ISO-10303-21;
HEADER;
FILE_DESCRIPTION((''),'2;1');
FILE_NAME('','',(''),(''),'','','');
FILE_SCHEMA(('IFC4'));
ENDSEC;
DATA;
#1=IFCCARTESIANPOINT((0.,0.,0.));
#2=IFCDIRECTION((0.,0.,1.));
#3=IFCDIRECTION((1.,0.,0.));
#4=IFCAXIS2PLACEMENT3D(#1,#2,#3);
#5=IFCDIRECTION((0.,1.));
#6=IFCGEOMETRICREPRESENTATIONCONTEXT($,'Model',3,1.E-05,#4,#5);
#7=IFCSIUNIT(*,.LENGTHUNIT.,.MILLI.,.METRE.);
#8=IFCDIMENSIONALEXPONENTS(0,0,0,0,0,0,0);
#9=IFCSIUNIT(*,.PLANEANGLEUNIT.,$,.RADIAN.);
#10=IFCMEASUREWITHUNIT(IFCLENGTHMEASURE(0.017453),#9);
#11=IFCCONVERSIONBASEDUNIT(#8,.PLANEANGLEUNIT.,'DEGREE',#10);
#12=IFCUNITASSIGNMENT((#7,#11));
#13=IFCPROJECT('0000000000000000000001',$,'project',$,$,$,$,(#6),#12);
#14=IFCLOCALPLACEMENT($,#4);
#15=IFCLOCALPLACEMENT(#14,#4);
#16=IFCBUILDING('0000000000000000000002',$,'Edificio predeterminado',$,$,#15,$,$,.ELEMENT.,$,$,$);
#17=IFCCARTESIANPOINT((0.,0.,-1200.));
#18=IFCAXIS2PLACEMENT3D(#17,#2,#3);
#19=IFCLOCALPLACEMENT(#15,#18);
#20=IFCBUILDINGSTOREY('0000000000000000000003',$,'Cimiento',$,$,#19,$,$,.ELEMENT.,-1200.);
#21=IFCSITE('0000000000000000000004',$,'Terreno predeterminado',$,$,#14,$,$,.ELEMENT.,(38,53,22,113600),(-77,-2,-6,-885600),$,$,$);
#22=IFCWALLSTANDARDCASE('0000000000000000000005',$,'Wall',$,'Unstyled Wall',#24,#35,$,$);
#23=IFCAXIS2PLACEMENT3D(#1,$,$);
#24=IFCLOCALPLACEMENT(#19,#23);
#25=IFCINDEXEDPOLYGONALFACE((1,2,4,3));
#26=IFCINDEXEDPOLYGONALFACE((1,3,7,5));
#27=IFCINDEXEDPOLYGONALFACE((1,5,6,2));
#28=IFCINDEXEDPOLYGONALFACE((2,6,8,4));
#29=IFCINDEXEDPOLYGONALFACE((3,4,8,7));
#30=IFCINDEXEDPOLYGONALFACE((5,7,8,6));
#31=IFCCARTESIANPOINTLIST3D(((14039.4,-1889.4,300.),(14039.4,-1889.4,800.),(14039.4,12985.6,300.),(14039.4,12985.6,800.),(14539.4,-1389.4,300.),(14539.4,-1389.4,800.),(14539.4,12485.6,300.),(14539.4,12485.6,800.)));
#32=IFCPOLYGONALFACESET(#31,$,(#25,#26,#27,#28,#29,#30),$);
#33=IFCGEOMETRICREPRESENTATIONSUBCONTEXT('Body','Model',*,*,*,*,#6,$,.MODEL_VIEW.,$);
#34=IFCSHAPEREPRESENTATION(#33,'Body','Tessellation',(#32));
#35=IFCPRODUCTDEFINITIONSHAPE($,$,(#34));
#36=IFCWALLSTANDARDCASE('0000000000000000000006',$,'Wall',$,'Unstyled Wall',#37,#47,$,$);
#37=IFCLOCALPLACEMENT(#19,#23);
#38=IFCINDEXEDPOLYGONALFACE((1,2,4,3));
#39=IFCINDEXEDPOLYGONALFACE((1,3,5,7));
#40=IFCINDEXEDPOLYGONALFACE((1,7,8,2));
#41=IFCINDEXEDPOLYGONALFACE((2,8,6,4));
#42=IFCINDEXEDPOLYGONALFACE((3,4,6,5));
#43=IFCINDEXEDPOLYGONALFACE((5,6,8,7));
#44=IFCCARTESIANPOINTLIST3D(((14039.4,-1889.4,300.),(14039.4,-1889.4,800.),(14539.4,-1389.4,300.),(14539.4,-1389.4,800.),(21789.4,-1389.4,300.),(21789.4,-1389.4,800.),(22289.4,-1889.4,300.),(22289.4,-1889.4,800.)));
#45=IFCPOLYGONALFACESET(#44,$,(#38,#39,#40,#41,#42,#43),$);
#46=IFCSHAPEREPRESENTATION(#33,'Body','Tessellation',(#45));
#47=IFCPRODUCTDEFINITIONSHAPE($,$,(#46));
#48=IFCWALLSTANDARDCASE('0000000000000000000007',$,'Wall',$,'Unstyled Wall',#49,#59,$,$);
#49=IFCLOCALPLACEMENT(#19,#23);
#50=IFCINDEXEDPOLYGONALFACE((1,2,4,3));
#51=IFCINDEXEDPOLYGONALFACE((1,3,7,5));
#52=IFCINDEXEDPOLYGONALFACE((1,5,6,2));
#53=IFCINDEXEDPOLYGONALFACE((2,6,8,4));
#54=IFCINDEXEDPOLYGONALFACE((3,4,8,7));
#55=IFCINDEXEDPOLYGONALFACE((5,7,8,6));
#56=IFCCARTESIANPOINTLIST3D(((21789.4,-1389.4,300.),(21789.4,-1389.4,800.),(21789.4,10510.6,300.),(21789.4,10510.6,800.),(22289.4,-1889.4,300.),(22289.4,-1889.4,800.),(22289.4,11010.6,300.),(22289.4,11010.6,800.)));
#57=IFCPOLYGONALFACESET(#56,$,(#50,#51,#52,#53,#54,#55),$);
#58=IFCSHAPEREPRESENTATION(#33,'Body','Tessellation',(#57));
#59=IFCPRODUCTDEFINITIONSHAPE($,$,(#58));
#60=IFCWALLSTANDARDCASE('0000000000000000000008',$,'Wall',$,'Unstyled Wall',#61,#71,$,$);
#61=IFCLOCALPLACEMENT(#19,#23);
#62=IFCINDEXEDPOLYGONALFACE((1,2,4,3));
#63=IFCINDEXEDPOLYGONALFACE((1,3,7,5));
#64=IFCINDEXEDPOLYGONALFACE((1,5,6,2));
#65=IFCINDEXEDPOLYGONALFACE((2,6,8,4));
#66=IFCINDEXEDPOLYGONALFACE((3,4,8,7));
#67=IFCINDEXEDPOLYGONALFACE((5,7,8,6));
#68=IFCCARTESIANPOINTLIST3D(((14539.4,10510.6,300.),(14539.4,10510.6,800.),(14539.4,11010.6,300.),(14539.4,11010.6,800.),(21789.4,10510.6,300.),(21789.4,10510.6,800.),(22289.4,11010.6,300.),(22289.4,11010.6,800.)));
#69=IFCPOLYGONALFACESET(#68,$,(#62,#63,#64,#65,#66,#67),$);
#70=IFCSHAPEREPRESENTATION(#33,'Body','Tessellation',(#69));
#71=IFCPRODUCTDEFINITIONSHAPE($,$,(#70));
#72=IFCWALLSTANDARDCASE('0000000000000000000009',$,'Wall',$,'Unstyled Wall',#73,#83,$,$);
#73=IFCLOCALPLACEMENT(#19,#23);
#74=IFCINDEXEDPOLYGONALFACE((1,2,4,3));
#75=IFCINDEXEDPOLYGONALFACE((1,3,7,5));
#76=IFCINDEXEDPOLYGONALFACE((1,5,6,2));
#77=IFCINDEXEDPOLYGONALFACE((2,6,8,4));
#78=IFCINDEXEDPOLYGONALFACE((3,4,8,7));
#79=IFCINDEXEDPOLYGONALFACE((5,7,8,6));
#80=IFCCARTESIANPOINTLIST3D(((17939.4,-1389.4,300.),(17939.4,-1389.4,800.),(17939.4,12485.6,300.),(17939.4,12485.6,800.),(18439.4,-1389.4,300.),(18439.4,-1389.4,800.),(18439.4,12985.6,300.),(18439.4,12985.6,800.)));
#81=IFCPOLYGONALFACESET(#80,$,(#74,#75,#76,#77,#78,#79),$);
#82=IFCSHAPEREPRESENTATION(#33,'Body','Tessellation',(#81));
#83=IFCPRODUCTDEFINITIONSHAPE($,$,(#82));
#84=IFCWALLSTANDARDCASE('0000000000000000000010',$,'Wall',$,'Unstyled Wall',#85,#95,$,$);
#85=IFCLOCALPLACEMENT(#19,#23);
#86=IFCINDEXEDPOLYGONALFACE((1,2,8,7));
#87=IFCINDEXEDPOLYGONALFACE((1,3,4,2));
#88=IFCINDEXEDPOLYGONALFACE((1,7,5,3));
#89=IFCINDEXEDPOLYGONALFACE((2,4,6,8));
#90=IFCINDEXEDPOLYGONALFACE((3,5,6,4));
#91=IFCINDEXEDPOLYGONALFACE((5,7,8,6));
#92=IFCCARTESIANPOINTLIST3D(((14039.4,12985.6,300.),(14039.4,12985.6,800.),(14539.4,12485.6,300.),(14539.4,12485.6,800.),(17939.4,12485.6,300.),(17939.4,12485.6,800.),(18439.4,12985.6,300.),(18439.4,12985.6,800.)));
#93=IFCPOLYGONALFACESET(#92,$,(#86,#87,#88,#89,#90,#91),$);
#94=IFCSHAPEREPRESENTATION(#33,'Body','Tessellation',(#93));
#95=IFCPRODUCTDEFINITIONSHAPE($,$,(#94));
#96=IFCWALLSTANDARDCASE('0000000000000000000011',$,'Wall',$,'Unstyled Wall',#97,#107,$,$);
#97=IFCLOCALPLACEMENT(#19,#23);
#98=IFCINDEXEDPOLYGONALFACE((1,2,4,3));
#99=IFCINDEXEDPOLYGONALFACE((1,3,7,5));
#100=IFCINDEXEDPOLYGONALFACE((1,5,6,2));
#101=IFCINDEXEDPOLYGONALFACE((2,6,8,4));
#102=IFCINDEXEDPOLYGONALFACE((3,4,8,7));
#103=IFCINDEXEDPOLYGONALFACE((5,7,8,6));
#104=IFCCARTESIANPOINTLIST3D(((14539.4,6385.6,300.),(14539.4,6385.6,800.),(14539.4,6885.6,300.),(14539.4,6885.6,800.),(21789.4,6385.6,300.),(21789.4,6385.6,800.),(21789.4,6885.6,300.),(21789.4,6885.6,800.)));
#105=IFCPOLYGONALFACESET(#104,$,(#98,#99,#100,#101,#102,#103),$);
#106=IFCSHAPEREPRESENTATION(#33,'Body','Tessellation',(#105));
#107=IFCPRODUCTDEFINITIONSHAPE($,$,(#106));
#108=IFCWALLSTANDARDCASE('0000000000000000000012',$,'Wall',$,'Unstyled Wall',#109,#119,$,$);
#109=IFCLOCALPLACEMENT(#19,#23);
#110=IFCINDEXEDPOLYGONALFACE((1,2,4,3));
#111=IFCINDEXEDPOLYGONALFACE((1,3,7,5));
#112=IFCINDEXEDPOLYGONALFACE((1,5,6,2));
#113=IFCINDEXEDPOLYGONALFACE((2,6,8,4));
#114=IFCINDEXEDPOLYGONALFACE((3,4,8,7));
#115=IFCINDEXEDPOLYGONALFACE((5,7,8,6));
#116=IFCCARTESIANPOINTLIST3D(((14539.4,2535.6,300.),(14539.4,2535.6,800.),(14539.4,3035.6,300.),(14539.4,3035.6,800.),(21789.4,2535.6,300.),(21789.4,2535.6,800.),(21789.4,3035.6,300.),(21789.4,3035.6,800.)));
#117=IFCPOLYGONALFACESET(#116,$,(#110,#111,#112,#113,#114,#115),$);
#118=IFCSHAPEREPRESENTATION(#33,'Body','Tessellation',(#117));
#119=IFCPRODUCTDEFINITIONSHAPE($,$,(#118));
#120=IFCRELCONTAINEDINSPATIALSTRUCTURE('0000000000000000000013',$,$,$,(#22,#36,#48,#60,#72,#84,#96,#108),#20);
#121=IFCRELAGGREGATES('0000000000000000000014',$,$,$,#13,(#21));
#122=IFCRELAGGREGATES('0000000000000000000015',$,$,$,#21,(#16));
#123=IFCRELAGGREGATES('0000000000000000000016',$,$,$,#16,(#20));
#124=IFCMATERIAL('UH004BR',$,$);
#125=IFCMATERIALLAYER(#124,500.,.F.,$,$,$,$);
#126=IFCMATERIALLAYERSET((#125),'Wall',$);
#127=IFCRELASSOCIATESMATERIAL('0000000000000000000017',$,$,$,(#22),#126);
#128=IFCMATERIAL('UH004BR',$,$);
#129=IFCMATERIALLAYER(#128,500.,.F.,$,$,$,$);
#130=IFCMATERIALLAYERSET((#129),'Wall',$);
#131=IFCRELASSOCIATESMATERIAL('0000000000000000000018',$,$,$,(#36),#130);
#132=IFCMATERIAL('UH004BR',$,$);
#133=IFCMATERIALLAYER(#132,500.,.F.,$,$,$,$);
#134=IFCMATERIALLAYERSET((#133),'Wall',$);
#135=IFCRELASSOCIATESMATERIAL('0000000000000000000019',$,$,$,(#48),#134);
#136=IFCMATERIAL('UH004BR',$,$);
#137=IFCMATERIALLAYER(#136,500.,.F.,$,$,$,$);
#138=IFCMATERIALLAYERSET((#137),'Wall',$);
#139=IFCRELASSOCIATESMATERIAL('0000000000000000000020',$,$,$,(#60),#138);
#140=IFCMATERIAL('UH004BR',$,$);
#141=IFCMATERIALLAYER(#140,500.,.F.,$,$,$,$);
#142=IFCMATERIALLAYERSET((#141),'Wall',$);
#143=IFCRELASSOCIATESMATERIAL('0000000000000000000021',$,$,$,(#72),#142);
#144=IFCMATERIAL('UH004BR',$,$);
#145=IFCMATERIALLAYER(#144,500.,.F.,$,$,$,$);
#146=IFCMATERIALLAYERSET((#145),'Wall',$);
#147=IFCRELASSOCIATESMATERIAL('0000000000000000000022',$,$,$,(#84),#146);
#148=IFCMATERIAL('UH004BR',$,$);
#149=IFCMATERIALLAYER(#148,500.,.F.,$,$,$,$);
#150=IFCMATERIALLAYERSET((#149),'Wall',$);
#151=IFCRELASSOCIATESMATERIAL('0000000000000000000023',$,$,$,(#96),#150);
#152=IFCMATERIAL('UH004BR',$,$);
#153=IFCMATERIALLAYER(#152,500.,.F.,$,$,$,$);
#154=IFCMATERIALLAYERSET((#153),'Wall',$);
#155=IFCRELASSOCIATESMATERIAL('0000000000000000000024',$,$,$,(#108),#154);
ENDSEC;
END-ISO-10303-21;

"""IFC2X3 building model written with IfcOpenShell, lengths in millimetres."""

from ifc_helpers import new_model, entity, si_unit, converted_unit, direction, frame, origin_with_axes, place, context, subcontext, project, spatial, polyline, outline, extrude, material, layer, layer_set, layer_usage, element, save


model = new_model("IFC2X3")

# Units and contexts
model_context = context("Model", 3, precision=1e-05, world=origin_with_axes(), true_north=direction((0.0, 1.0)))
body_context = subcontext(model_context, "Body", "Model", "MODEL_VIEW")
ifc_project = project(units=[si_unit("LENGTHUNIT", "METRE", prefix="MILLI"), converted_unit("PLANEANGLEUNIT", "DEGREE", entity("IfcLengthMeasure", 0.017453), si_unit("PLANEANGLEUNIT", "RADIAN"), dimensions=[0, 0, 0, 0, 0, 0, 0])], contexts=[model_context])

# Site, building, storey
site_placement = place(None, origin_with_axes())
site = spatial("IfcSite", under=ifc_project, at=site_placement, Name="Terreno predeterminado", CompositionType="ELEMENT", RefLatitude=(38, 53, 22, 113600), RefLongitude=(-77, -2, -6, -885600))
building_placement = place(site_placement, origin_with_axes())
building = spatial("IfcBuilding", under=site, at=building_placement, Name="Edificio predeterminado", CompositionType="ELEMENT")
storey_placement = place(building_placement, frame((0.0, 0.0, -1200.0), z_axis=(0.0, 0.0, 1.0), x_axis=(1.0, 0.0, 0.0)))
storey = spatial("IfcBuildingStorey", under=building, at=storey_placement, Name="Cimiento", CompositionType="ELEMENT", Elevation=-1200.0)

# Walls
ifc_material_1 = material(Name="UH004BR")
ifc_layer_1 = layer(ifc_material_1, 500.0, ventilated=False)
ifc_layer_set_1 = layer_set([ifc_layer_1], Name="Wall")
ifc_layer_usage_1 = layer_usage(ifc_layer_set_1, "AXIS2", "POSITIVE", -250.0)
wall_1_placement = place(storey_placement, frame((14289.4, 12735.6, 300.0), z_axis=(0.0, 0.0, 1.0), x_axis=(0.0, -1.0, 0.0)))
element("IfcWallStandardCase", 1, at=wall_1_placement, inside=storey, material=ifc_layer_usage_1, Name="Wall", ObjectType="Unstyled Wall", context=body_context, shape_type="SweptSolid", body=[
    extrude(outline(polyline([(250.0, 250.0), (-250.0, -250.0), (14625.0, -250.0), (14125.0, 250.0), (250.0, 250.0)])), origin_with_axes(), (0.0, 0.0, 1.0), 500.0),
])
ifc_material_2 = material(Name="UH004BR")
ifc_layer_2 = layer(ifc_material_2, 500.0, ventilated=False)
ifc_layer_set_2 = layer_set([ifc_layer_2], Name="Wall")
ifc_layer_usage_2 = layer_usage(ifc_layer_set_2, "AXIS2", "POSITIVE", -250.0)
wall_2_placement = place(storey_placement, frame((14289.4, -1639.4, 300.0), z_axis=(0.0, 0.0, 1.0), x_axis=(1.0, 0.0, 0.0)))
element("IfcWallStandardCase", 2, at=wall_2_placement, inside=storey, material=ifc_layer_usage_2, Name="Wall", ObjectType="Unstyled Wall", context=body_context, shape_type="SweptSolid", body=[
    extrude(outline(polyline([(-250.0, -250.0), (250.0, 250.0), (7500.0, 250.0), (8000.0, -250.0), (-250.0, -250.0)])), origin_with_axes(), (0.0, 0.0, 1.0), 500.0),
])
ifc_material_3 = material(Name="UH004BR")
ifc_layer_3 = layer(ifc_material_3, 500.0, ventilated=False)
ifc_layer_set_3 = layer_set([ifc_layer_3], Name="Wall")
ifc_layer_usage_3 = layer_usage(ifc_layer_set_3, "AXIS2", "POSITIVE", -250.0)
wall_3_placement = place(storey_placement, frame((22039.4, -1639.4, 300.0), z_axis=(0.0, 0.0, 1.0), x_axis=(0.0, 1.0, 0.0)))
element("IfcWallStandardCase", 3, at=wall_3_placement, inside=storey, material=ifc_layer_usage_3, Name="Wall", ObjectType="Unstyled Wall", context=body_context, shape_type="SweptSolid", body=[
    extrude(outline(polyline([(-250.0, -250.0), (250.0, 250.0), (12150.0, 250.0), (12650.0, -250.0), (-250.0, -250.0)])), origin_with_axes(), (0.0, 0.0, 1.0), 500.0),
])
ifc_material_4 = material(Name="UH004BR")
ifc_layer_4 = layer(ifc_material_4, 500.0, ventilated=False)
ifc_layer_set_4 = layer_set([ifc_layer_4], Name="Wall")
ifc_layer_usage_4 = layer_usage(ifc_layer_set_4, "AXIS2", "POSITIVE", -250.0)
wall_4_placement = place(storey_placement, frame((22039.4, 10760.6, 300.0), z_axis=(0.0, 0.0, 1.0), x_axis=(-1.0, 0.0, 0.0)))
element("IfcWallStandardCase", 4, at=wall_4_placement, inside=storey, material=ifc_layer_usage_4, Name="Wall", ObjectType="Unstyled Wall", context=body_context, shape_type="SweptSolid", body=[
    extrude(outline(polyline([(-250.0, -250.0), (250.0, 250.0), (7500.0, 250.0), (7500.0, -250.0), (-250.0, -250.0)])), origin_with_axes(), (0.0, 0.0, 1.0), 500.0),
])
ifc_material_5 = material(Name="UH004BR")
ifc_layer_5 = layer(ifc_material_5, 500.0, ventilated=False)
ifc_layer_set_5 = layer_set([ifc_layer_5], Name="Wall")
ifc_layer_usage_5 = layer_usage(ifc_layer_set_5, "AXIS2", "POSITIVE", -250.0)
wall_5_placement = place(storey_placement, frame((18189.4, -1639.4, 300.0), z_axis=(0.0, 0.0, 1.0), x_axis=(0.0, 1.0, 0.0)))
element("IfcWallStandardCase", 5, at=wall_5_placement, inside=storey, material=ifc_layer_usage_5, Name="Wall", ObjectType="Unstyled Wall", context=body_context, shape_type="SweptSolid", body=[
    extrude(outline(polyline([(250.0, 250.0), (250.0, -250.0), (14625.0, -250.0), (14125.0, 250.0), (250.0, 250.0)])), origin_with_axes(), (0.0, 0.0, 1.0), 500.0),
])
ifc_material_6 = material(Name="UH004BR")
ifc_layer_6 = layer(ifc_material_6, 500.0, ventilated=False)
ifc_layer_set_6 = layer_set([ifc_layer_6], Name="Wall")
ifc_layer_usage_6 = layer_usage(ifc_layer_set_6, "AXIS2", "POSITIVE", -250.0)
wall_6_placement = place(storey_placement, frame((18189.4, 12735.6, 300.0), z_axis=(0.0, 0.0, 1.0), x_axis=(-1.0, 0.0, 0.0)))
element("IfcWallStandardCase", 6, at=wall_6_placement, inside=storey, material=ifc_layer_usage_6, Name="Wall", ObjectType="Unstyled Wall", context=body_context, shape_type="SweptSolid", body=[
    extrude(outline(polyline([(-250.0, -250.0), (250.0, 250.0), (3650.0, 250.0), (4150.0, -250.0), (-250.0, -250.0)])), origin_with_axes(), (0.0, 0.0, 1.0), 500.0),
])
ifc_material_7 = material(Name="UH004BR")
ifc_layer_7 = layer(ifc_material_7, 500.0, ventilated=False)
ifc_layer_set_7 = layer_set([ifc_layer_7], Name="Wall")
ifc_layer_usage_7 = layer_usage(ifc_layer_set_7, "AXIS2", "POSITIVE", -250.0)
wall_7_placement = place(storey_placement, frame((14289.4, 6635.6, 300.0), z_axis=(0.0, 0.0, 1.0), x_axis=(1.0, 0.0, 0.0)))
element("IfcWallStandardCase", 7, at=wall_7_placement, inside=storey, material=ifc_layer_usage_7, Name="Wall", ObjectType="Unstyled Wall", context=body_context, shape_type="SweptSolid", body=[
    extrude(outline(polyline([(250.0, -250.0), (250.0, 250.0), (7500.0, 250.0), (7500.0, -250.0), (250.0, -250.0)])), origin_with_axes(), (0.0, 0.0, 1.0), 500.0),
])
ifc_material_8 = material(Name="UH004BR")
ifc_layer_8 = layer(ifc_material_8, 500.0, ventilated=False)
ifc_layer_set_8 = layer_set([ifc_layer_8], Name="Wall")
ifc_layer_usage_8 = layer_usage(ifc_layer_set_8, "AXIS2", "POSITIVE", -250.0)
wall_8_placement = place(storey_placement, frame((14289.4, 2785.6, 300.0), z_axis=(0.0, 0.0, 1.0), x_axis=(1.0, 0.0, 0.0)))
element("IfcWallStandardCase", 8, at=wall_8_placement, inside=storey, material=ifc_layer_usage_8, Name="Wall", ObjectType="Unstyled Wall", context=body_context, shape_type="SweptSolid", body=[
    extrude(outline(polyline([(250.0, -250.0), (250.0, 250.0), (7500.0, 250.0), (7500.0, -250.0), (250.0, -250.0)])), origin_with_axes(), (0.0, 0.0, 1.0), 500.0),
])

save(model, "model.ifc")
